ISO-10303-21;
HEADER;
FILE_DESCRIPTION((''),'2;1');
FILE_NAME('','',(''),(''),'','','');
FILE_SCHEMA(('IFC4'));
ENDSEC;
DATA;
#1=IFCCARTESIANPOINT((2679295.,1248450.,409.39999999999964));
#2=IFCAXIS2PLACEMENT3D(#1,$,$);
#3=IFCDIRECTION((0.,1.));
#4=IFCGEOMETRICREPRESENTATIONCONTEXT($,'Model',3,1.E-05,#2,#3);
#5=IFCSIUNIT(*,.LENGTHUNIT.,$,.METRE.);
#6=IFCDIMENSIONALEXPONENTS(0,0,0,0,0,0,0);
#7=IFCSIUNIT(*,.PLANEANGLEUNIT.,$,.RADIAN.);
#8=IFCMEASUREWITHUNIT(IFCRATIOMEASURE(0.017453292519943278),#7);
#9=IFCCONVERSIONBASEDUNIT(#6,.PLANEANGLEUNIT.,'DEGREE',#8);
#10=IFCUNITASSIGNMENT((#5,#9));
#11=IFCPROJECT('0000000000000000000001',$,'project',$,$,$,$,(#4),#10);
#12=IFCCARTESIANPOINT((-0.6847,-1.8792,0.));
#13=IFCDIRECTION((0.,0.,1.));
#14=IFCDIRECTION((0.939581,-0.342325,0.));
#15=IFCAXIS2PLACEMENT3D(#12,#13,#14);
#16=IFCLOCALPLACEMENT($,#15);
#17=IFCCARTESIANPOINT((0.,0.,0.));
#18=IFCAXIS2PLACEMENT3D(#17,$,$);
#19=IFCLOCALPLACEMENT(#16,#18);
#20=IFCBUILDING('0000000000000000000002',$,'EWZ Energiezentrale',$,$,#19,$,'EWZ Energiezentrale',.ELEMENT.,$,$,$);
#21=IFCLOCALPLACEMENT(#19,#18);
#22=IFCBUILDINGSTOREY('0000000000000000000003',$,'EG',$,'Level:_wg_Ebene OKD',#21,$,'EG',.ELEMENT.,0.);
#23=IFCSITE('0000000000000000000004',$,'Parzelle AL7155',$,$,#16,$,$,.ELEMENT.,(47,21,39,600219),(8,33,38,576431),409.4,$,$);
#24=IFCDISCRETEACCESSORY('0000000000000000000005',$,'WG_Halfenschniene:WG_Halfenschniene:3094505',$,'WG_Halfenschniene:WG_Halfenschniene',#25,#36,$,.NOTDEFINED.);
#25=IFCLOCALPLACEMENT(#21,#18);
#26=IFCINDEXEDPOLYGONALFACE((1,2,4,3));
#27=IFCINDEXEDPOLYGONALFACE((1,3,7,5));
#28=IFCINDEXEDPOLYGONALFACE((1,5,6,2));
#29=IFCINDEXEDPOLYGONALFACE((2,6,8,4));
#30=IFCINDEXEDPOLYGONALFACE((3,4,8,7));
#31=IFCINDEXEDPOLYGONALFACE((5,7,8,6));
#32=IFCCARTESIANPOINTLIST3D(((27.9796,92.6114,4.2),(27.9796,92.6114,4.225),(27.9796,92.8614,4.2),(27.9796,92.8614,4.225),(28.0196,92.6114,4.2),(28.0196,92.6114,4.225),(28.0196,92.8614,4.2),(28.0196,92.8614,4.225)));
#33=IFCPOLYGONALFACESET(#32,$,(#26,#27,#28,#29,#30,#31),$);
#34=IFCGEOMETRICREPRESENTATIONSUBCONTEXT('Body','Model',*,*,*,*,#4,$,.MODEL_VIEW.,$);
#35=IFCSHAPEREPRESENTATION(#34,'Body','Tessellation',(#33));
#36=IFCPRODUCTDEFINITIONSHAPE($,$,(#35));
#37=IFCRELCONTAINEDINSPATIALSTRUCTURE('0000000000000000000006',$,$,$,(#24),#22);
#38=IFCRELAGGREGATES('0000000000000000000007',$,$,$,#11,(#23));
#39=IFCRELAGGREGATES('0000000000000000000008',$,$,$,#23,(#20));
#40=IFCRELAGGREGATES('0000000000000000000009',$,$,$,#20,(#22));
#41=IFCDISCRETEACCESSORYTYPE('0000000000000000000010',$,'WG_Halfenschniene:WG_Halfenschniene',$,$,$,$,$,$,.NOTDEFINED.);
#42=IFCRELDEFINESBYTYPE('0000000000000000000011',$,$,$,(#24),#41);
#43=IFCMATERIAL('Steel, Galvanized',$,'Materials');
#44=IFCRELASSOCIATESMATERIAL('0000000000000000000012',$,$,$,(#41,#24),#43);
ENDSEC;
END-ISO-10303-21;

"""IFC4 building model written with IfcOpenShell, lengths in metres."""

from ifc_helpers import new_model, entity, si_unit, converted_unit, direction, frame, origin, place, context, subcontext, project, spatial, indexed_curve, outline, extrude, source, transform, mapped, material, type_object, element, save


model = new_model("IFC4")

# Units and contexts
model_context = context("Model", 3, precision=1e-05, world=frame((2679295.0, 1248450.0, 409.39999999999964)), true_north=direction((0.0, 1.0)))
body_context = subcontext(model_context, "Body", "Model", "MODEL_VIEW")
ifc_project = project(units=[si_unit("LENGTHUNIT", "METRE"), converted_unit("PLANEANGLEUNIT", "DEGREE", entity("IfcRatioMeasure", 0.017453292519943278), si_unit("PLANEANGLEUNIT", "RADIAN"), dimensions=[0, 0, 0, 0, 0, 0, 0])], contexts=[model_context])

# Site, building, storey
site_placement = place(None, frame((-0.6847, -1.8792, 0.0), z_axis=(0.0, 0.0, 1.0), x_axis=(0.939581, -0.342325, 0.0)))
site = spatial("IfcSite", under=ifc_project, at=site_placement, Name="Parzelle AL7155", CompositionType="ELEMENT", RefLatitude=(47, 21, 39, 600219), RefLongitude=(8, 33, 38, 576431), RefElevation=409.4)
building_placement = place(site_placement, origin())
building = spatial("IfcBuilding", under=site, at=building_placement, Name="EWZ Energiezentrale", LongName="EWZ Energiezentrale", CompositionType="ELEMENT")
storey_placement = place(building_placement, origin())
storey = spatial("IfcBuildingStorey", under=building, at=storey_placement, Name="EG", ObjectType="Level:_wg_Ebene OKD", LongName="EG", CompositionType="ELEMENT", Elevation=0.0)

# Discrete accessory
ifc_material = material(Name="Steel, Galvanized", Category="Materials")
discrete_accessory_type = type_object("IfcDiscreteAccessoryType", Name="WG_Halfenschniene:WG_Halfenschniene", PredefinedType="NOTDEFINED", material=ifc_material)
shared_shape = source(origin(), body_context, "Body", "SweptSolid", [
    extrude(outline(indexed_curve([(-0.125, -0.02), (0.125, -0.02), (0.125, 0.02), (-0.125, 0.02), (-0.125, -0.02)], self_intersect=False)), frame((0.125, 0.0, -0.0125)), (0.0, 0.0, 1.0), 0.025),
])
for number, where, z_axis, x_axis, name in (
    (1, (27.9996, 92.6114, 4.2125), (0.0, 0.0, -1.0), (0.0, 1.0, 0.0), "WG_Halfenschniene:WG_Halfenschniene:3094505"),
):
    element("IfcDiscreteAccessory", number, at=place(storey_placement, frame(where, z_axis=z_axis, x_axis=x_axis)), inside=storey, type_object=discrete_accessory_type, material=ifc_material, Name=name, ObjectType="WG_Halfenschniene:WG_Halfenschniene", PredefinedType="NOTDEFINED", context=body_context, shape_type="MappedRepresentation", body=[
        mapped(shared_shape, transform((0.0, 0.0, 0.0), scale=1.0)),
    ])

save(model, "model.ifc")
